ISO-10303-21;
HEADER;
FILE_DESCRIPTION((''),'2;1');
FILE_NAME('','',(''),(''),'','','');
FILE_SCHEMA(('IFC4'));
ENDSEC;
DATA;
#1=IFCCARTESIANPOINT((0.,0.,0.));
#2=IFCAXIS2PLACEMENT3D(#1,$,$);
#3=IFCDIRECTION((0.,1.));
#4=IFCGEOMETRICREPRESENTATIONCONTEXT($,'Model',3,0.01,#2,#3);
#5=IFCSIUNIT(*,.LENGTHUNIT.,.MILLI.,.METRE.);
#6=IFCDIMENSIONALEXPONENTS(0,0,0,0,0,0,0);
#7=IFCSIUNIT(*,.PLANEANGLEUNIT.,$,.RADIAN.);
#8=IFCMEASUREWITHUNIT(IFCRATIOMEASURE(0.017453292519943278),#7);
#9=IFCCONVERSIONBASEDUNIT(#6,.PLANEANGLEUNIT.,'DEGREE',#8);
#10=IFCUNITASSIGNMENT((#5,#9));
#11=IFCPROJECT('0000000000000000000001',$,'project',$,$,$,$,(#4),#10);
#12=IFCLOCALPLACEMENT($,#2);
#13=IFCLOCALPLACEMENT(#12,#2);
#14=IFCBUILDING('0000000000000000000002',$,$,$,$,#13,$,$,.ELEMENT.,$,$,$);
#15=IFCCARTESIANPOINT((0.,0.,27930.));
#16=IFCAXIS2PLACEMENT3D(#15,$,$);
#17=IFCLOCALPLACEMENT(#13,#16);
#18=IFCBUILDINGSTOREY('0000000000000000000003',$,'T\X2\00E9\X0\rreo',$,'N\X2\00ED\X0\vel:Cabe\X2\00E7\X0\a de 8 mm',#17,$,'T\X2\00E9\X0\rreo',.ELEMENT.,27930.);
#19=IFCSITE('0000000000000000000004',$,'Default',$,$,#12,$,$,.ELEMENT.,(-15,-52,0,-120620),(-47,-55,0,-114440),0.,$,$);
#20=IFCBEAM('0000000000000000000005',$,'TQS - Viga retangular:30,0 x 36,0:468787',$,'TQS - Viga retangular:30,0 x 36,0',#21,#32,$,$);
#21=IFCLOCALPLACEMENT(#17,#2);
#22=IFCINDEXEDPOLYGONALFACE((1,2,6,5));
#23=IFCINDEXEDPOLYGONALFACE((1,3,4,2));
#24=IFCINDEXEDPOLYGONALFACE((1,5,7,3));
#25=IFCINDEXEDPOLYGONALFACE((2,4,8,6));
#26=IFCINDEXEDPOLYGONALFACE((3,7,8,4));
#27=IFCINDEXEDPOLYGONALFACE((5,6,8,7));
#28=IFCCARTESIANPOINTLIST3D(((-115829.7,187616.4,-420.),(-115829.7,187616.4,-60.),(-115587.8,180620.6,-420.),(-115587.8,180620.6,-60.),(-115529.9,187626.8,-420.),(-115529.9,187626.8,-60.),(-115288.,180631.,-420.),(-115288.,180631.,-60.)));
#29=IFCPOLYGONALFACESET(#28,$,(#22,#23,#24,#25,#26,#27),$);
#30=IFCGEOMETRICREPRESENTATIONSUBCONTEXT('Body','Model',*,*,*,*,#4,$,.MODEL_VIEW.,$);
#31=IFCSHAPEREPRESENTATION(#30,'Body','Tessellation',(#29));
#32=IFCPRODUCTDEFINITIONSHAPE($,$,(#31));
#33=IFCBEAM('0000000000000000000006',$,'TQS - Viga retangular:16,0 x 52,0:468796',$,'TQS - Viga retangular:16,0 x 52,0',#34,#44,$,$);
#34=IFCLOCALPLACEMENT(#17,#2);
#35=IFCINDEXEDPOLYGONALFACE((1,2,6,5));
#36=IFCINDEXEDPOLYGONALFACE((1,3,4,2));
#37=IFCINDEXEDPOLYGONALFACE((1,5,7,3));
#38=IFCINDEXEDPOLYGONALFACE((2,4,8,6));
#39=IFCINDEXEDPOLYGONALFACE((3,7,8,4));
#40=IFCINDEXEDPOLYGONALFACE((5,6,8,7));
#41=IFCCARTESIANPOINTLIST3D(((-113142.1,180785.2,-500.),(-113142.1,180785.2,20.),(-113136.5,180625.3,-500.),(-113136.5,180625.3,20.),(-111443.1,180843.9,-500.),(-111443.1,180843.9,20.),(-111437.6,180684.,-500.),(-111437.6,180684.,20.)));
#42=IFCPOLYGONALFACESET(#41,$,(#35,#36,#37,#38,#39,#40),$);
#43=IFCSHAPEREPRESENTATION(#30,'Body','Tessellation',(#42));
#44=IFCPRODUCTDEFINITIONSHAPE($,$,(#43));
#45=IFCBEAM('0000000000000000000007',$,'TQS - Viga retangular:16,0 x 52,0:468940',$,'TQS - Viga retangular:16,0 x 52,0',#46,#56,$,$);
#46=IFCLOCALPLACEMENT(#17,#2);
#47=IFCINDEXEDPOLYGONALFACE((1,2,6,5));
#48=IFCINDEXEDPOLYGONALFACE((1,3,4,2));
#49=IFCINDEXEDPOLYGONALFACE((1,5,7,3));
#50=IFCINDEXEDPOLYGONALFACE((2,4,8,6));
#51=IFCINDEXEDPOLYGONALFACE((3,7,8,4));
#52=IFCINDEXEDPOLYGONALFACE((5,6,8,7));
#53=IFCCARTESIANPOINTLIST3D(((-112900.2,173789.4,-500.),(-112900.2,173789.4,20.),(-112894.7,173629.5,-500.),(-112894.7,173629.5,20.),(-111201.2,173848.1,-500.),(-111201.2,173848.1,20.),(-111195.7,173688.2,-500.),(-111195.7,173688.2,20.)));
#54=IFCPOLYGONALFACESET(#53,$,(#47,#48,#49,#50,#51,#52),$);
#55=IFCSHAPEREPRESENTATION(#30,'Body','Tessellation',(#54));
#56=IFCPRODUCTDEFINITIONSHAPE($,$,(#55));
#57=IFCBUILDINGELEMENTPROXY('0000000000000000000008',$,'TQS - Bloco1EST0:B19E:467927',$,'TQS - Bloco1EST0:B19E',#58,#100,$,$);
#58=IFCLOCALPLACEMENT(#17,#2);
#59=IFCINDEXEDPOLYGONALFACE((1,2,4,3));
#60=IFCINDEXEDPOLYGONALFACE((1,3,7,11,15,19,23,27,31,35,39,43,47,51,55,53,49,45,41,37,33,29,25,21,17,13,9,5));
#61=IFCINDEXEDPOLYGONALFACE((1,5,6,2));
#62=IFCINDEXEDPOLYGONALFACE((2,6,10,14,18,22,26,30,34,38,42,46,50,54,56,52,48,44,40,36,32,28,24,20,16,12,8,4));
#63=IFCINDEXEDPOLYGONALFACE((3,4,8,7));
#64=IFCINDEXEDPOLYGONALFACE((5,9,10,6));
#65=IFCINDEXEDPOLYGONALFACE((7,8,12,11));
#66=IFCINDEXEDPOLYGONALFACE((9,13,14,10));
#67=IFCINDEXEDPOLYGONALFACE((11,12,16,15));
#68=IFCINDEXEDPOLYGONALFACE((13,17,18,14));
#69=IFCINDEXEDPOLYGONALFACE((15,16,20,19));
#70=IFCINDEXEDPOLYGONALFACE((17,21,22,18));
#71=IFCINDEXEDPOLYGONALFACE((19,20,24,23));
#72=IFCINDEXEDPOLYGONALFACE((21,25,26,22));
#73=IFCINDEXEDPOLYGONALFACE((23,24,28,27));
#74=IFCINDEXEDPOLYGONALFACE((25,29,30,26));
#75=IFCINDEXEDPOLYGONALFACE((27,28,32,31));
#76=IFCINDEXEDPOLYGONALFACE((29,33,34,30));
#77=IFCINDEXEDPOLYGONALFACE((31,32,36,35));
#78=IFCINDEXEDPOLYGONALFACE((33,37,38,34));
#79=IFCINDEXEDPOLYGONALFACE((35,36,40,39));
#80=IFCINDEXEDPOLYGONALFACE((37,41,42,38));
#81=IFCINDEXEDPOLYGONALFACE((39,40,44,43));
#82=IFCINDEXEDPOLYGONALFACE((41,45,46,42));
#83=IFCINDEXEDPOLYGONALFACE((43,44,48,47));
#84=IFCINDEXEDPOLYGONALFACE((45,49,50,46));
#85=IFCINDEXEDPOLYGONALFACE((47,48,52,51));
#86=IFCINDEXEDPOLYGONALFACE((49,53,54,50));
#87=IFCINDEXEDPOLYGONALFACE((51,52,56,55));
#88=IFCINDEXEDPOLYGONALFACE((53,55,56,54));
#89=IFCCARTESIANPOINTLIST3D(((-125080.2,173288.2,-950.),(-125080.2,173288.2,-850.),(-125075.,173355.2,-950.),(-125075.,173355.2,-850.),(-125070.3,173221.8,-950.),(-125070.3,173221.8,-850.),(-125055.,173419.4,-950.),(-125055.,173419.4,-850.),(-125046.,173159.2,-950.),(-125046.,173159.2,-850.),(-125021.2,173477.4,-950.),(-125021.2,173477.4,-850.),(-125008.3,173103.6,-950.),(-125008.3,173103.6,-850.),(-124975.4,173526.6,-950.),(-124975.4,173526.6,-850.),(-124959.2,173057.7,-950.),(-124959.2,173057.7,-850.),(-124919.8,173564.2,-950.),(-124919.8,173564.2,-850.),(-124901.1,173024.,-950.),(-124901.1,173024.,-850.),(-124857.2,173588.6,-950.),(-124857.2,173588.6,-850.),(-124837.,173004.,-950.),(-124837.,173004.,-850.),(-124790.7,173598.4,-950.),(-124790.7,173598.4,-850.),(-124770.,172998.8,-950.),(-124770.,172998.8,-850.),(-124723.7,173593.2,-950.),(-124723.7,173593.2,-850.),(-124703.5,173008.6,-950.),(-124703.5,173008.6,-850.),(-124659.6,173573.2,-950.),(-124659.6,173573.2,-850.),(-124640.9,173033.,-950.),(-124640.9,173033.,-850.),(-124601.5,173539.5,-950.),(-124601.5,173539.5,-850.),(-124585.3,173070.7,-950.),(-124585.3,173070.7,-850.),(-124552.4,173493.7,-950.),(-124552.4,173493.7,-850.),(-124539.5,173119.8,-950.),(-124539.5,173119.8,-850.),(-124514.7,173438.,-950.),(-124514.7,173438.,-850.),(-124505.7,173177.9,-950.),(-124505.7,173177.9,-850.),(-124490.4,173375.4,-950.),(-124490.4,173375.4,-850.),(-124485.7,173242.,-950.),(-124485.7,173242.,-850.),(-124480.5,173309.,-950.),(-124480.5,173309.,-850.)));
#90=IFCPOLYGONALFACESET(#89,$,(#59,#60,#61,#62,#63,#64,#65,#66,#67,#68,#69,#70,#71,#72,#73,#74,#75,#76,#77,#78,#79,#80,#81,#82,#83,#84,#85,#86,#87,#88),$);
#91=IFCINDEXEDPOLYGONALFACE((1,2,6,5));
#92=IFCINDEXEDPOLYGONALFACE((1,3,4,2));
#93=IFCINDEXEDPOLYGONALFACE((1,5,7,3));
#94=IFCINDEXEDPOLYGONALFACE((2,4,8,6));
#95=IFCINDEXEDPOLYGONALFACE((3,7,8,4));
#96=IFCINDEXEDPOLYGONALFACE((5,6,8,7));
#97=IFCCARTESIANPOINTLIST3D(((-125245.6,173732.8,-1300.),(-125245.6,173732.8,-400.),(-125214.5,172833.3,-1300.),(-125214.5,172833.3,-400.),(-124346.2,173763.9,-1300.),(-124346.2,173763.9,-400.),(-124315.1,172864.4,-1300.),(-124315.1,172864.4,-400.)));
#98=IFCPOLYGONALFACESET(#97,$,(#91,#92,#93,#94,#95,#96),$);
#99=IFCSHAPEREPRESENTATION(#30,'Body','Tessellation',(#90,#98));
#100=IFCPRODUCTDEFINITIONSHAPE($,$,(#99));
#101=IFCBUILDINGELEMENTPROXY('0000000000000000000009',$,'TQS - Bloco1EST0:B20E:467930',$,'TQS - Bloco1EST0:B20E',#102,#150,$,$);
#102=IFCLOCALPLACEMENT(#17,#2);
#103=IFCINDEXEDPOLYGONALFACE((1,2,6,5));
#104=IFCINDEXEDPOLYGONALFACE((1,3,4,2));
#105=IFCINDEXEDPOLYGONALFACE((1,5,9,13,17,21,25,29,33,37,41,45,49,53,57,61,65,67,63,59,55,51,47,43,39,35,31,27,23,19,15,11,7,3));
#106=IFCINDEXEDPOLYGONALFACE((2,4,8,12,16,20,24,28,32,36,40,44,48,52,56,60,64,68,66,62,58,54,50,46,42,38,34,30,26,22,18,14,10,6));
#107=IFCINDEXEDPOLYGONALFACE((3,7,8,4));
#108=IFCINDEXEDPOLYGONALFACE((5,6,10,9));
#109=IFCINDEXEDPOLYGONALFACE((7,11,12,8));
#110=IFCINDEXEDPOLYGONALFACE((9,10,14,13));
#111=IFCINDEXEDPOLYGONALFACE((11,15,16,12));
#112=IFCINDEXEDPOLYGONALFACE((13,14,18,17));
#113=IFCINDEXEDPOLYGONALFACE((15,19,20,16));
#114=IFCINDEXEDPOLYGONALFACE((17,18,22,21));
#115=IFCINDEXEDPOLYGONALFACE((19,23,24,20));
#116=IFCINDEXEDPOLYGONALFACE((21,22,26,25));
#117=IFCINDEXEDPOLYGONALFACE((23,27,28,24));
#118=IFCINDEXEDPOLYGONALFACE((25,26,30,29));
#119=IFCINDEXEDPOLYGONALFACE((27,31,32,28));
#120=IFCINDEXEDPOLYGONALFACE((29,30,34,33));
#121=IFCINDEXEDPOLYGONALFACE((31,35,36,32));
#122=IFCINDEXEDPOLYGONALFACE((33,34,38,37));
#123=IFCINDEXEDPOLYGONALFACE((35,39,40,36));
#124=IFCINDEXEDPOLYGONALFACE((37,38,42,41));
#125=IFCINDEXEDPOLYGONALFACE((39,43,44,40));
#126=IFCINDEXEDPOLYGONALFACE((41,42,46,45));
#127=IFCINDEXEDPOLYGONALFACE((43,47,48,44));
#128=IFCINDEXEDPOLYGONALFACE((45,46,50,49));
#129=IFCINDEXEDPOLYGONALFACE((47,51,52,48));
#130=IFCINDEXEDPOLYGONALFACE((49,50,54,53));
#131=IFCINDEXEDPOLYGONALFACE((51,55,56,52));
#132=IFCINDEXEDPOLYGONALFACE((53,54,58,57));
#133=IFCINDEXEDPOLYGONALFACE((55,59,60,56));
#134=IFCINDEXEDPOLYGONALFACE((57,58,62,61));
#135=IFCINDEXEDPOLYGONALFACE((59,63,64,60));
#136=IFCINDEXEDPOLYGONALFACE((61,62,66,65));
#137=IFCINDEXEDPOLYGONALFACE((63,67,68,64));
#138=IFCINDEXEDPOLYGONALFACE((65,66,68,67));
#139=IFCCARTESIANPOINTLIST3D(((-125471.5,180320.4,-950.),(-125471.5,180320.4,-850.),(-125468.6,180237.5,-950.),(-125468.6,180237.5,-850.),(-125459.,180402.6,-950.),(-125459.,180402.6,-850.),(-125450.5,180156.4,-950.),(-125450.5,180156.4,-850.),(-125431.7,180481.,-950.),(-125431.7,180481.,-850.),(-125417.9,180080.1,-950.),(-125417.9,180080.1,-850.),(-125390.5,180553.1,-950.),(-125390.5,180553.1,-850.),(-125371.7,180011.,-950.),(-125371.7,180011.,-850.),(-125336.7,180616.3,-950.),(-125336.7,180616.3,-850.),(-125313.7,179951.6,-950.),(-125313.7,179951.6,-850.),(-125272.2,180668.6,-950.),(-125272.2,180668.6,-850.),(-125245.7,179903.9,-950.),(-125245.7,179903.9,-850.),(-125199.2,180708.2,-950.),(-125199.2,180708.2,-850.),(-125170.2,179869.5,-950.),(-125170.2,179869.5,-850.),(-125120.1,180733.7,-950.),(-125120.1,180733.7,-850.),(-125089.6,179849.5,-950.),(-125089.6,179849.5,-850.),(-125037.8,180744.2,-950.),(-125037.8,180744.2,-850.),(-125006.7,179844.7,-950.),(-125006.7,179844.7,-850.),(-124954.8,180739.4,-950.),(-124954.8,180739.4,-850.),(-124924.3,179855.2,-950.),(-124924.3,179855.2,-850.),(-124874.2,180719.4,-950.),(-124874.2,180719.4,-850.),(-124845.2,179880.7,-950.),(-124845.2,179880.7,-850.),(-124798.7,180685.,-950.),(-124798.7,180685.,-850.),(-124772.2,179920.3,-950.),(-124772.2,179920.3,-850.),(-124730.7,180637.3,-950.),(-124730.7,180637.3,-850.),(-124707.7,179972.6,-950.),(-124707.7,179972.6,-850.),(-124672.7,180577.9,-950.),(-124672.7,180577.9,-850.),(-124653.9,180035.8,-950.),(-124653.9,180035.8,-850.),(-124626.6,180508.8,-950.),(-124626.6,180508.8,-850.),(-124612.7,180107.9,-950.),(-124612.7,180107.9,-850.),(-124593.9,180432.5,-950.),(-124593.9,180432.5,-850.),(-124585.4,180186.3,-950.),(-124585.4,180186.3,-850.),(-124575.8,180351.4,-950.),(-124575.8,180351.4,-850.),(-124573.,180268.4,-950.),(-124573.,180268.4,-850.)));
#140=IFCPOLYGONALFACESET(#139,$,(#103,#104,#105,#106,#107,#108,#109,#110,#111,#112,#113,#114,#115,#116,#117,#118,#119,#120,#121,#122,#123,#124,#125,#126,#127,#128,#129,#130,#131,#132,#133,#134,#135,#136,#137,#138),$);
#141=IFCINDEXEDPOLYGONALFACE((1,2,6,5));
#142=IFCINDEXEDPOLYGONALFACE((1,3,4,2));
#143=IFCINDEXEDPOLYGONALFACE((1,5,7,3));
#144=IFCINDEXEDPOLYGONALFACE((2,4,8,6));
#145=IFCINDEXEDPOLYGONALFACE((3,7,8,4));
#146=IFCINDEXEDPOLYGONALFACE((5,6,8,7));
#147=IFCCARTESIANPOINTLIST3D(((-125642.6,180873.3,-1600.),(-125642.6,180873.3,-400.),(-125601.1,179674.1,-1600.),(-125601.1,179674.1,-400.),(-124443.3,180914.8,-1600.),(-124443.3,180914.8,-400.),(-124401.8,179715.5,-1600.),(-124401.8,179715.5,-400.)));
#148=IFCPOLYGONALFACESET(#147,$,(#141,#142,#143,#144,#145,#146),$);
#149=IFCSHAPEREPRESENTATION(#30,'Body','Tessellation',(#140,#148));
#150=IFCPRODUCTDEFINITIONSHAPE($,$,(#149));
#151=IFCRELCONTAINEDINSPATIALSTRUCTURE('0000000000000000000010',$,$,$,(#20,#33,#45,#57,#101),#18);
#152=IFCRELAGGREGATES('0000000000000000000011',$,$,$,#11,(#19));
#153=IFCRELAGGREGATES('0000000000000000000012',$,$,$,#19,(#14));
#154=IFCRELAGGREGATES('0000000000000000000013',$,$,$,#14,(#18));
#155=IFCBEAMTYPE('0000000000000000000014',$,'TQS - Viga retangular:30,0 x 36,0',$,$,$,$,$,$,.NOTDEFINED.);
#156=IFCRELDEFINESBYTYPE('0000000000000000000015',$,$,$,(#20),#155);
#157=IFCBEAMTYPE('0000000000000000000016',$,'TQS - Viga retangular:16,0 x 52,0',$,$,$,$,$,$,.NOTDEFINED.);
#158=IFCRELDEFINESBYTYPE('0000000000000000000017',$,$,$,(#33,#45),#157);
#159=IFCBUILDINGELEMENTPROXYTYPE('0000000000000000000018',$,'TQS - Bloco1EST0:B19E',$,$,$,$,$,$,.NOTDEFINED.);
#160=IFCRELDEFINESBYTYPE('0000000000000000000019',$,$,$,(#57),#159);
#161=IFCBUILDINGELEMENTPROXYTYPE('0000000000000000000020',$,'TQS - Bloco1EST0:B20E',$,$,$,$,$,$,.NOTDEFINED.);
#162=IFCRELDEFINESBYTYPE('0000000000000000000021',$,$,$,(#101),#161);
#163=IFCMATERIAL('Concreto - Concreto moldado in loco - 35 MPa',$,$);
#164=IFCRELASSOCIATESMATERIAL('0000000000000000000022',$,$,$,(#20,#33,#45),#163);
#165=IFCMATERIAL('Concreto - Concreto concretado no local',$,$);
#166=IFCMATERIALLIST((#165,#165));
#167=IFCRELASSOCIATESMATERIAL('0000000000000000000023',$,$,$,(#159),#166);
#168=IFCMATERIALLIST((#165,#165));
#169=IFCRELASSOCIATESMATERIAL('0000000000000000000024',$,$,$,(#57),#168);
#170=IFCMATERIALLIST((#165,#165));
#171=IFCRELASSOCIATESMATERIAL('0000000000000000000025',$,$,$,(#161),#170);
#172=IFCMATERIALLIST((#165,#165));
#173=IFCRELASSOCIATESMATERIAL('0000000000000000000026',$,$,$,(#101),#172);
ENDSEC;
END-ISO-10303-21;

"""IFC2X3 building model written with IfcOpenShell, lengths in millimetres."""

from ifc_helpers import new_model, entity, si_unit, converted_unit, direction, frame, frame_2d, origin, origin_2d_with_axis, place, context, subcontext, project, spatial, rectangle, circle, extrude, source, transform, mapped, material, material_list, type_object, type_shapes, element, save


model = new_model("IFC2X3")

# Units and contexts
model_context = context("Model", 3, precision=0.01, world=origin(), true_north=direction((0.0, 1.0)))
body_context = subcontext(model_context, "Body", "Model", "MODEL_VIEW")
ifc_project = project(units=[si_unit("LENGTHUNIT", "METRE", prefix="MILLI"), converted_unit("PLANEANGLEUNIT", "DEGREE", entity("IfcRatioMeasure", 0.017453292519943278), si_unit("PLANEANGLEUNIT", "RADIAN"), dimensions=[0, 0, 0, 0, 0, 0, 0])], contexts=[model_context])

# Site, building, storey
site_placement = place(None, origin())
site = spatial("IfcSite", under=ifc_project, at=site_placement, Name="Default", CompositionType="ELEMENT", RefLatitude=(-15, -52, 0, -120620), RefLongitude=(-47, -55, 0, -114440), RefElevation=0.0)
building_placement = place(site_placement, origin())
building = spatial("IfcBuilding", under=site, at=building_placement, CompositionType="ELEMENT")
storey_placement = place(building_placement, frame((0.0, 0.0, 27930.0)))
storey = spatial("IfcBuildingStorey", under=building, at=storey_placement, Name="Térreo", ObjectType="Nível:Cabeça de 8 mm", LongName="Térreo", CompositionType="ELEMENT", Elevation=27930.0)

# Beams
ifc_material_1 = material(Name="Concreto - Concreto moldado in loco - 35 MPa")
beam_type_1 = type_object("IfcBeamType", Name="TQS - Viga retangular:30,0 x 36,0", PredefinedType="NOTDEFINED")
beam_1_placement = place(storey_placement, frame((-115437.9, 180625.8, -60.0), z_axis=(0.0, 0.0, 1.0), x_axis=(-0.034551, 0.999403, 0.0)))
element("IfcBeam", 1, at=beam_1_placement, inside=storey, type_object=beam_type_1, material=ifc_material_1, Name="TQS - Viga retangular:30,0 x 36,0:468787", ObjectType="TQS - Viga retangular:30,0 x 36,0", context=body_context, shape_type="SweptSolid", body=[
    extrude(rectangle(XDim=360.0, YDim=300.0, at=frame_2d((0.0, 0.0), x_axis=(1.0, 0.0))), frame((0.0, 0.0, -180.0), z_axis=(1.0, 0.0, 0.0), x_axis=(0.0, 0.0, -1.0)), (0.0, 0.0, 1.0), 7000.0),
])
beam_type_2 = type_object("IfcBeamType", Name="TQS - Viga retangular:16,0 x 52,0", PredefinedType="NOTDEFINED")
beam_2_placement = place(storey_placement, frame((-111440.3, 180764.0, 20.0), z_axis=(0.0, 0.0, 1.0), x_axis=(-0.999403, -0.034551, 0.0)))
element("IfcBeam", 2, at=beam_2_placement, inside=storey, type_object=beam_type_2, material=ifc_material_1, Name="TQS - Viga retangular:16,0 x 52,0:468796", ObjectType="TQS - Viga retangular:16,0 x 52,0", context=body_context, shape_type="SweptSolid", body=[
    extrude(rectangle(XDim=520.0, YDim=160.0, at=frame_2d((0.0, 0.0), x_axis=(1.0, 0.0))), frame((0.0, 0.0, -260.0), z_axis=(1.0, 0.0, 0.0), x_axis=(0.0, 0.0, -1.0)), (0.0, 0.0, 1.0), 1700.0),
])
beam_3_placement = place(storey_placement, frame((-111198.5, 173768.2, 20.0), z_axis=(0.0, 0.0, 1.0), x_axis=(-0.999403, -0.034551, 0.0)))
element("IfcBeam", 3, at=beam_3_placement, inside=storey, type_object=beam_type_2, material=ifc_material_1, Name="TQS - Viga retangular:16,0 x 52,0:468940", ObjectType="TQS - Viga retangular:16,0 x 52,0", context=body_context, shape_type="SweptSolid", body=[
    extrude(rectangle(XDim=520.0, YDim=160.0, at=frame_2d((0.0, 0.0), x_axis=(1.0, 0.0))), frame((0.0, 0.0, -260.0), z_axis=(1.0, 0.0, 0.0), x_axis=(0.0, 0.0, -1.0)), (0.0, 0.0, 1.0), 1700.0),
])

# Building element proxies
ifc_material_2 = material(Name="Concreto - Concreto concretado no local")
ifc_material_list_1 = material_list([ifc_material_2, ifc_material_2])
ifc_material_list_2 = material_list([ifc_material_2, ifc_material_2])
building_element_proxy_type_1 = type_object("IfcBuildingElementProxyType", Name="TQS - Bloco1EST0:B19E", PredefinedType="NOTDEFINED", material=ifc_material_list_2)
shared_shape_1 = source(origin(), body_context, "Body", "SweptSolid", [
    extrude(circle(Radius=300.0, at=frame_2d((0.0, 0.0), x_axis=(1.0, 0.0))), frame((0.0, 0.0, -550.0)), (0.0, 0.0, 1.0), 100.0),
    extrude(rectangle(XDim=900.0, YDim=900.0, at=origin_2d_with_axis()), frame((0.0, 0.0, -900.0), z_axis=(0.0, 0.0, 1.0), x_axis=(-1.0, 0.0, 0.0)), (0.0, 0.0, 1.0), 900.0),
])
type_shapes(building_element_proxy_type_1, [shared_shape_1])
proxy_1_placement = place(storey_placement, frame((-124780.4, 173298.6, -400.0), z_axis=(0.0, 0.0, 1.0), x_axis=(-0.034551, 0.999403, 0.0)))
element("IfcBuildingElementProxy", 4, at=proxy_1_placement, inside=storey, type_object=building_element_proxy_type_1, material=ifc_material_list_1, Name="TQS - Bloco1EST0:B19E:467927", ObjectType="TQS - Bloco1EST0:B19E", context=body_context, shape_type="MappedRepresentation", body=[
    mapped(shared_shape_1, transform((0.0, 0.0, 0.0), scale=1.0)),
])
ifc_material_list_3 = material_list([ifc_material_2, ifc_material_2])
ifc_material_list_4 = material_list([ifc_material_2, ifc_material_2])
building_element_proxy_type_2 = type_object("IfcBuildingElementProxyType", Name="TQS - Bloco1EST0:B20E", PredefinedType="NOTDEFINED", material=ifc_material_list_4)
shared_shape_2 = source(origin(), body_context, "Body", "SweptSolid", [
    extrude(circle(Radius=450.0, at=frame_2d((0.0, 0.0), x_axis=(1.0, 0.0))), frame((0.0, 0.0, -550.0)), (0.0, 0.0, 1.0), 100.0),
    extrude(rectangle(XDim=1200.0, YDim=1200.0, at=origin_2d_with_axis()), frame((0.0, 0.0, -1200.0), z_axis=(0.0, 0.0, 1.0), x_axis=(-1.0, 0.0, 0.0)), (0.0, 0.0, 1.0), 1200.0),
])
type_shapes(building_element_proxy_type_2, [shared_shape_2])
proxy_2_placement = place(storey_placement, frame((-125022.2, 180294.4, -400.0), z_axis=(0.0, 0.0, 1.0), x_axis=(-0.034551, 0.999403, 0.0)))
element("IfcBuildingElementProxy", 5, at=proxy_2_placement, inside=storey, type_object=building_element_proxy_type_2, material=ifc_material_list_3, Name="TQS - Bloco1EST0:B20E:467930", ObjectType="TQS - Bloco1EST0:B20E", context=body_context, shape_type="MappedRepresentation", body=[
    mapped(shared_shape_2, transform((0.0, 0.0, 0.0), scale=1.0)),
])

save(model, "model.ifc")
